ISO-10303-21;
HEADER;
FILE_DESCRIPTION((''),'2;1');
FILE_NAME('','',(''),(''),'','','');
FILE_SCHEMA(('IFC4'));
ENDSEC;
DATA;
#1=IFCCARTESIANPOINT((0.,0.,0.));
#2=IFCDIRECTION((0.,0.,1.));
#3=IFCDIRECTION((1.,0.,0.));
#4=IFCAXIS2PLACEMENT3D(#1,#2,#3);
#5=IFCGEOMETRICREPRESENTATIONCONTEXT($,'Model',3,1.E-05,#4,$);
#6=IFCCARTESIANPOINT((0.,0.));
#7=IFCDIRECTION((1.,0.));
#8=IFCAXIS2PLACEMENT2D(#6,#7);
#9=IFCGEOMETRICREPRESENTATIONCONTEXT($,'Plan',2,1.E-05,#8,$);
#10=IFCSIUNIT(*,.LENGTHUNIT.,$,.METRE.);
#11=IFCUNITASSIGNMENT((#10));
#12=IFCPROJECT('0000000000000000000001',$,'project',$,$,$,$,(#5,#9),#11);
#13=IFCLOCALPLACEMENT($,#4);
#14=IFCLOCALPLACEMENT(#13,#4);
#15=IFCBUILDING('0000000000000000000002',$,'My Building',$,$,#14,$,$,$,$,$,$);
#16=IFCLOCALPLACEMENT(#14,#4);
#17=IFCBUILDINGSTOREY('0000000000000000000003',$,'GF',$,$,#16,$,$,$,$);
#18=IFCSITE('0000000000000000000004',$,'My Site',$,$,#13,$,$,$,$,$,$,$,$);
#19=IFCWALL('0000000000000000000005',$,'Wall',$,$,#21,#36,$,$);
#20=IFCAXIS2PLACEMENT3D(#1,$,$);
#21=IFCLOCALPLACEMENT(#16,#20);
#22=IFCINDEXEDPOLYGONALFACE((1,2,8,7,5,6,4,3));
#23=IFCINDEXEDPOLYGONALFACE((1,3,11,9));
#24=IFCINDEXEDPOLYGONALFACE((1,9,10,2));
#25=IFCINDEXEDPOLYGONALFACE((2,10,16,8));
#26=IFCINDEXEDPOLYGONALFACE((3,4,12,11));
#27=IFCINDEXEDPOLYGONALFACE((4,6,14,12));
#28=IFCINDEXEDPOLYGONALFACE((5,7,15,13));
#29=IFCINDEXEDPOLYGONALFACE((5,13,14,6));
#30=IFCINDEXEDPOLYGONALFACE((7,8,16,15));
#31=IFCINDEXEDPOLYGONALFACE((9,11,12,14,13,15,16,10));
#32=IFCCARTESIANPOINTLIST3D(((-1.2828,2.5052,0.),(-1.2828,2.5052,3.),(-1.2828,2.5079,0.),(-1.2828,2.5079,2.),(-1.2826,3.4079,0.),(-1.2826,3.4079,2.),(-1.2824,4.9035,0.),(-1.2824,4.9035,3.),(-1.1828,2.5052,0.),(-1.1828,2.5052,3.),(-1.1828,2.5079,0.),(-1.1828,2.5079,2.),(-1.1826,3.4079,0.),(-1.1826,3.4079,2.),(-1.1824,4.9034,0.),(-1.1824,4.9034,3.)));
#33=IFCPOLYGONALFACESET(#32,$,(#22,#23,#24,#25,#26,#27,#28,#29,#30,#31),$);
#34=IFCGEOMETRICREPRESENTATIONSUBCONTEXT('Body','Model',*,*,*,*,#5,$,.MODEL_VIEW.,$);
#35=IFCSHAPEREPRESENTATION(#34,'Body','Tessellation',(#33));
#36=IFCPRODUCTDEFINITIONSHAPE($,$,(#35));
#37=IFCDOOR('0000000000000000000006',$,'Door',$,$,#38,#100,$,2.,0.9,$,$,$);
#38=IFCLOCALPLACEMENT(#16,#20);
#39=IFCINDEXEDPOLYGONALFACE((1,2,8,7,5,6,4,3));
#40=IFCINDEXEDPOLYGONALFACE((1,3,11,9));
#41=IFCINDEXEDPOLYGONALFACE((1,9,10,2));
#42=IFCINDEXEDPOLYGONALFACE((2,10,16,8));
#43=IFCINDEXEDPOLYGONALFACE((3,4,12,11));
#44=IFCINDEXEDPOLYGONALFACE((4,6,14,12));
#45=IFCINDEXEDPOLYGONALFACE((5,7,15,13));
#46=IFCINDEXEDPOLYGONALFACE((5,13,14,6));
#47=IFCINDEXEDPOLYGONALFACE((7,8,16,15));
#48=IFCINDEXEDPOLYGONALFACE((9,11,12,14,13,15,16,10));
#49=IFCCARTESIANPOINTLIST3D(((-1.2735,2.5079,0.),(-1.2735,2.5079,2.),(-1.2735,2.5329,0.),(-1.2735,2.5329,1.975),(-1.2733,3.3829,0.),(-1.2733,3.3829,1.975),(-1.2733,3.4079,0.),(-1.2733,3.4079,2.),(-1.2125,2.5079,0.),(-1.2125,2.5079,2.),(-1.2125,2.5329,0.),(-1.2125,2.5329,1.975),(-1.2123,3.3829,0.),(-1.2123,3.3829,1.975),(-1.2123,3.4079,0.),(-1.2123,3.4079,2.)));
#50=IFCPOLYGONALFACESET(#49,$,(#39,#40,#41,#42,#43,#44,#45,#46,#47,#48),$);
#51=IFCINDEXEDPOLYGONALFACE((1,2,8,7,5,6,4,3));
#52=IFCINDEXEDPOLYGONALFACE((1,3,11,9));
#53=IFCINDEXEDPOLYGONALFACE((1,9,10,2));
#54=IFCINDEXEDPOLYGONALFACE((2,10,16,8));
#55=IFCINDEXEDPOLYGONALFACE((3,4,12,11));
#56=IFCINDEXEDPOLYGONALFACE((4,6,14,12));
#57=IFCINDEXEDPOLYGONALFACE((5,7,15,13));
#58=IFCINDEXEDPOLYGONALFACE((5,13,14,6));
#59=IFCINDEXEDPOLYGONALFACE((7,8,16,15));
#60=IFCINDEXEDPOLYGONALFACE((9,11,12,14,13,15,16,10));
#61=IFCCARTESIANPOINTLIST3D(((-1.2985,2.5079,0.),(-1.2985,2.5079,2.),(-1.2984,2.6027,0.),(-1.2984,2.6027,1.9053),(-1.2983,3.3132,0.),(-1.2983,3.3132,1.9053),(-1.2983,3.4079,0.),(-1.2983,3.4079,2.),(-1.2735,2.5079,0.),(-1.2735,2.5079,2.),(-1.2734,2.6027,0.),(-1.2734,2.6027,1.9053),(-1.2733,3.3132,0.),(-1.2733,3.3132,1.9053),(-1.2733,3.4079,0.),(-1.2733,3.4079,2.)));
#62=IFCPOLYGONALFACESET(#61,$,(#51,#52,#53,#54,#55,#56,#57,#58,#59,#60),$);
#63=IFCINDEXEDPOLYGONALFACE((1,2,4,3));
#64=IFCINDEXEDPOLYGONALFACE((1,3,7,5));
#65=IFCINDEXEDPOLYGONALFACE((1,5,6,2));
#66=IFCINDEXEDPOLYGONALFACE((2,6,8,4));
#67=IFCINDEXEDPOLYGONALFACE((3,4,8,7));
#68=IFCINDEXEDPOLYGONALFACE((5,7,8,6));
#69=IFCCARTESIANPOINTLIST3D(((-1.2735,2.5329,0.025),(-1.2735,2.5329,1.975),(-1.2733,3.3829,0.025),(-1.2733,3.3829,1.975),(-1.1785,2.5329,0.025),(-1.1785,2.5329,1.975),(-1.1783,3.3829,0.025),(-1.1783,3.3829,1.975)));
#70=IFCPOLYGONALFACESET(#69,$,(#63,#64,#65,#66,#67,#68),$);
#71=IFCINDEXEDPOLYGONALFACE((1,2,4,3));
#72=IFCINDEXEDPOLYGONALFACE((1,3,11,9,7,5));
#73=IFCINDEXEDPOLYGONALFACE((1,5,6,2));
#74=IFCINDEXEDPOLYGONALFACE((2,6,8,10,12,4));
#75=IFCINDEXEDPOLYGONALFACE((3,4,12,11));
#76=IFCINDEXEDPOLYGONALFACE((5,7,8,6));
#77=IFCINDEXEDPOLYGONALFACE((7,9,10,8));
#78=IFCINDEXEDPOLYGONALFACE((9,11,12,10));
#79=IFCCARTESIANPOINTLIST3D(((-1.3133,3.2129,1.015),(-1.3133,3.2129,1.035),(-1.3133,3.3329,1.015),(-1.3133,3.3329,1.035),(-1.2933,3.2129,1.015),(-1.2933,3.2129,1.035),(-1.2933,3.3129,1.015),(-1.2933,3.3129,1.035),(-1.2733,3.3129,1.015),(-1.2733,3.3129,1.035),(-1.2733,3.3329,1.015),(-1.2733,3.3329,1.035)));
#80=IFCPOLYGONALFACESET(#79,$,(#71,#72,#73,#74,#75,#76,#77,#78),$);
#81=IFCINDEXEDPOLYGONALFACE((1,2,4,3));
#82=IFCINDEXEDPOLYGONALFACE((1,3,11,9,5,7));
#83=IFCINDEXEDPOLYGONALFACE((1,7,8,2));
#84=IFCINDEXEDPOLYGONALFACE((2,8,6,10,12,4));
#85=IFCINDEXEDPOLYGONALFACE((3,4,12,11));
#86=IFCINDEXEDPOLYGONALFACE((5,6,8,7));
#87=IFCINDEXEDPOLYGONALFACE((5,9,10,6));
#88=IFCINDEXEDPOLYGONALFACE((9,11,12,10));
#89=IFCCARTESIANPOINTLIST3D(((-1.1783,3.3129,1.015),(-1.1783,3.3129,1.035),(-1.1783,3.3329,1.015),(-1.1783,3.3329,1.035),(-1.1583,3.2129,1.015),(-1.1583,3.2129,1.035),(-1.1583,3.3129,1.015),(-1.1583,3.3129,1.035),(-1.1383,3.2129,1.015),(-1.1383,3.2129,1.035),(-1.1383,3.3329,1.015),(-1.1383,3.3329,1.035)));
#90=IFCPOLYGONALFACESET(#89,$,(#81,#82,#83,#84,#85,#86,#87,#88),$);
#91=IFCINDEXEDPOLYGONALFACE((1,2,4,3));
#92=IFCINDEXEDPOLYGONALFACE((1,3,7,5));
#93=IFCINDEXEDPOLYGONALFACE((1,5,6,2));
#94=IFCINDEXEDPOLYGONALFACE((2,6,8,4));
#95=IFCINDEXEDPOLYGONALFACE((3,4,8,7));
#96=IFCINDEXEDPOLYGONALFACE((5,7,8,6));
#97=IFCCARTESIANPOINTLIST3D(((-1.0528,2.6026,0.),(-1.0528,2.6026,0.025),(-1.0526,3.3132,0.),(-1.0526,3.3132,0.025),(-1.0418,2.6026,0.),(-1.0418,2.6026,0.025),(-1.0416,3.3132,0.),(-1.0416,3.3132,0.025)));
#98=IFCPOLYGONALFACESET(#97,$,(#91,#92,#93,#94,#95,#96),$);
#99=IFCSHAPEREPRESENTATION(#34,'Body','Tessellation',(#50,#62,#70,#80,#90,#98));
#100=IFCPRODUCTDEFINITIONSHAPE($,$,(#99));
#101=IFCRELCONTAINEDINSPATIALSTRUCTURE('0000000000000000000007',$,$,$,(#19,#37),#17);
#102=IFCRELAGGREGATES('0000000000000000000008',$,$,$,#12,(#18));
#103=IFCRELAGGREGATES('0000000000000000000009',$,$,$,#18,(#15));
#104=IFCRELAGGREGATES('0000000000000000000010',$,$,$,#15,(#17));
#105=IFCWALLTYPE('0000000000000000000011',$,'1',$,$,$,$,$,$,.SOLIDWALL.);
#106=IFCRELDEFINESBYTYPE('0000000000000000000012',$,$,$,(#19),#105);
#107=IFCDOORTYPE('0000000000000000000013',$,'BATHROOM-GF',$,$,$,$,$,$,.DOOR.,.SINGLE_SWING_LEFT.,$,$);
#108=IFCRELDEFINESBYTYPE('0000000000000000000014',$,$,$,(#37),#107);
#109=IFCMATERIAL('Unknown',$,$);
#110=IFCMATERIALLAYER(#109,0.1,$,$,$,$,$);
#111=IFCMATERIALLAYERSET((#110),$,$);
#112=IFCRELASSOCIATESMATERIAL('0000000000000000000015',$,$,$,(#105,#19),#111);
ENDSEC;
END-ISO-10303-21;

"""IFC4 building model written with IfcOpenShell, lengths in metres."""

from ifc_helpers import new_model, entity, si_unit, frame, origin_with_axes, origin_2d_with_axis, place, context, subcontext, project, spatial, line, indexed_curve, outline, extrude, shape, source, transform, mapped, material, layer, layer_set, layer_usage, type_object, type_shapes, element, fill, save


model = new_model("IFC4")

# Units and contexts
model_context = context("Model", 3, precision=1e-05, world=origin_with_axes())
plan_context = context("Plan", 2, precision=1e-05, world=origin_2d_with_axis())
body_context_1 = subcontext(model_context, "Body", "Model", "MODEL_VIEW")
body_context_2 = subcontext(plan_context, "Body", "Plan", "PLAN_VIEW")
ifc_project = project(units=[si_unit("LENGTHUNIT", "METRE")], contexts=[model_context, plan_context])

# Site, building, storey
site_placement = place(None, origin_with_axes())
site = spatial("IfcSite", under=ifc_project, at=site_placement, Name="My Site")
building_placement = place(site_placement, origin_with_axes())
building = spatial("IfcBuilding", under=site, at=building_placement, Name="My Building")
storey_placement = place(building_placement, origin_with_axes())
storey = spatial("IfcBuildingStorey", under=building, at=storey_placement, Name="GF")

# Shared definitions
ifc_material_1 = material(Name="Unknown")

# Shared definitions
ifc_layer_1 = layer(ifc_material_1, 0.1)
ifc_layer_set_1 = layer_set([ifc_layer_1])
wall_type_1 = type_object("IfcWallType", Name="1", PredefinedType="SOLIDWALL", material=ifc_layer_set_1)

# Wall, opening, door
ifc_layer_usage_1 = layer_usage(ifc_layer_set_1, "AXIS2", "POSITIVE", 0.0)
wall_1_placement = place(storey_placement, frame((-1.1828, 2.5052, 0.0), z_axis=(0.0, 0.0, 1.0), x_axis=(0.000169, 1.0, 0.0)))
wall_1 = element("IfcWall", 1, at=wall_1_placement, inside=storey, type_object=wall_type_1, material=ifc_layer_usage_1, Name="Wall", context=body_context_1, shape_type="SweptSolid", body=[
    extrude(outline(indexed_curve([(0.0, 0.0), (0.0, 0.1), (2.3983, 0.1), (2.3983, 0.0)], segments=[line(1, 2, 3, 4, 1)])), origin_with_axes(), (0.0, 0.0, 1.0), 3.0),
])
shared_shape_1 = source(origin_with_axes(), body_context_1, "Body", "SweptSolid", [
    extrude(outline(indexed_curve([(0.0, 0.0), (0.9, 0.0), (0.9, 2.0), (0.0, 2.0)], segments=[line(1, 2, 3, 4, 1)])), frame((0.0, -0.6, 0.0), z_axis=(0.0, -1.0, 0.0), x_axis=(1.0, 0.0, 0.0)), (0.0, 0.0, -1.0), 1.2),
])
opening_1_placement = place(wall_1_placement, frame((0.9027, 0.1, 0.0), z_axis=(0.0, 0.0, 1.0), x_axis=(-1.0, 0.0, 0.0)))
opening_1 = element("IfcOpeningElement", 2, at=opening_1_placement, cuts=wall_1, PredefinedType="OPENING", context=body_context_1, shape_type="MappedRepresentation", body=[
    mapped(shared_shape_1, transform((0.0, 0.0, 0.0), x_axis=(1.0, 0.0, 0.0), y_axis=(0.0, 1.0, 0.0), z_axis=(0.0, 0.0, 1.0), scale=1.0)),
])
door_type_1 = type_object("IfcDoorType", Name="BATHROOM-GF", OperationType="SINGLE_SWING_LEFT", PredefinedType="DOOR")
shared_shape_2 = source(origin_with_axes(), body_context_1, "Body", "SweptSolid", [
    extrude(outline(indexed_curve([(0.0, 0.0), (0.0, 2.0), (0.9, 2.0), (0.9, 0.0), (0.875, 0.0), (0.875, 1.975), (0.025, 1.975), (0.025, 0.0)], segments=[line(1, 2, 3, 4, 5, 6, 7, 8, 1)])), frame((0.0, 0.0093, 0.0), z_axis=(0.0, -1.0, 0.0), x_axis=(1.0, 0.0, 0.0)), (0.0, 0.0, -1.0), 0.061),
    extrude(outline(indexed_curve([(0.0, 0.0), (0.0, 2.0), (0.9, 2.0), (0.9, 0.0), (0.8053, 0.0), (0.8053, 1.9053), (0.0947, 1.9053), (0.0947, 0.0)], segments=[line(1, 2, 3, 4, 5, 6, 7, 8, 1)])), frame((0.0, -0.0157, 0.0), z_axis=(0.0, -1.0, 0.0), x_axis=(1.0, 0.0, 0.0)), (0.0, 0.0, -1.0), 0.025),
    extrude(outline(indexed_curve([(0.0, 0.0), (0.85, 0.0), (0.85, 0.095), (0.0, 0.095)], segments=[line(1, 2, 3, 4, 1)])), frame((0.025, 0.0093, 0.025), z_axis=(0.0, 0.0, 1.0), x_axis=(1.0, 0.0, 0.0)), (0.0, 0.0, 1.0), 1.95),
    extrude(outline(indexed_curve([(0.0, 0.0), (0.0, -0.04), (0.12, -0.04), (0.12, -0.02), (0.02, -0.02), (0.02, 0.0)], segments=[line(1, 2, 3, 4, 5, 6, 1)])), frame((0.075, 0.0093, 1.015), z_axis=(0.0, 0.0, 1.0), x_axis=(1.0, 0.0, 0.0)), (0.0, 0.0, 1.0), 0.02),
    extrude(outline(indexed_curve([(0.0, 0.0), (0.0, 0.04), (0.12, 0.04), (0.12, 0.02), (0.02, 0.02), (0.02, 0.0)], segments=[line(1, 2, 3, 4, 5, 6, 1)])), frame((0.075, 0.1043, 1.015), z_axis=(0.0, 0.0, 1.0), x_axis=(1.0, 0.0, 0.0)), (0.0, 0.0, 1.0), 0.02),
    extrude(outline(indexed_curve([(0.0, 0.0), (0.7105, 0.0), (0.7105, 0.011), (0.0, 0.011)], segments=[line(1, 2, 3, 4, 1)])), frame((0.0947, 0.23, 0.0), z_axis=(0.0, 0.0, 1.0), x_axis=(1.0, 0.0, 0.0)), (0.0, 0.0, 1.0), 0.025),
])
shared_shape_3 = source(origin_with_axes(), body_context_2, "Body", "Curve2D", [
    entity("IfcIndexedPolyCurve", entity("IfcCartesianPointList2D", [[0.0, -0.0157], [0.0, 0.0703], [0.025, 0.0703], [0.025, 0.0093], [0.0947, 0.0093], [0.0947, -0.0157]]), [entity("IfcLineIndex", [1, 2, 3, 4, 5, 6, 1])]),
    entity("IfcIndexedPolyCurve", entity("IfcCartesianPointList2D", [[0.9, -0.0157], [0.9, 0.0703], [0.875, 0.0703], [0.875, 0.0093], [0.8053, 0.0093], [0.8053, -0.0157]]), [entity("IfcLineIndex", [1, 2, 3, 4, 5, 6, 1])]),
    entity("IfcTrimmedCurve", entity("IfcEllipse", entity("IfcAxis2Placement2D", entity("IfcCartesianPoint", [0.78, 0.0703]), entity("IfcDirection", [1.0, 0.0])), 0.755, 0.85), [entity("IfcCartesianPoint", [0.78, 0.9203])], [entity("IfcCartesianPoint", [0.025, 0.0703])], True, "CARTESIAN"),
    entity("IfcIndexedPolyCurve", entity("IfcCartesianPointList2D", [[0.875, 0.0703], [0.78, 0.0703], [0.78, 0.9203], [0.875, 0.9203]]), [entity("IfcLineIndex", [1, 2, 3, 4, 1])]),
])
type_shapes(door_type_1, [shared_shape_2, shared_shape_3])
door_1_placement = place(opening_1_placement, frame((0.0, 0.0, 0.0), z_axis=(0.0, 0.0, 1.0), x_axis=(1.0, 0.0, 0.0)))
door_1 = element("IfcDoor", 3, at=door_1_placement, inside=storey, type_object=door_type_1, Name="Door", OverallHeight=2.0, OverallWidth=0.9, shapes=[
    shape(body_context_1, "Body", "MappedRepresentation", [mapped(shared_shape_2, transform((0.0, 0.0, 0.0), x_axis=(1.0, 0.0, 0.0), y_axis=(0.0, 1.0, 0.0), z_axis=(0.0, 0.0, 1.0), scale=1.0))]),
    shape(body_context_2, "Body", "MappedRepresentation", [mapped(shared_shape_3, transform((0.0, 0.0, 0.0), x_axis=(1.0, 0.0, 0.0), y_axis=(0.0, 1.0, 0.0), z_axis=(0.0, 0.0, 1.0), scale=1.0))]),
])
fill(opening_1, door_1)

save(model, "model.ifc")
